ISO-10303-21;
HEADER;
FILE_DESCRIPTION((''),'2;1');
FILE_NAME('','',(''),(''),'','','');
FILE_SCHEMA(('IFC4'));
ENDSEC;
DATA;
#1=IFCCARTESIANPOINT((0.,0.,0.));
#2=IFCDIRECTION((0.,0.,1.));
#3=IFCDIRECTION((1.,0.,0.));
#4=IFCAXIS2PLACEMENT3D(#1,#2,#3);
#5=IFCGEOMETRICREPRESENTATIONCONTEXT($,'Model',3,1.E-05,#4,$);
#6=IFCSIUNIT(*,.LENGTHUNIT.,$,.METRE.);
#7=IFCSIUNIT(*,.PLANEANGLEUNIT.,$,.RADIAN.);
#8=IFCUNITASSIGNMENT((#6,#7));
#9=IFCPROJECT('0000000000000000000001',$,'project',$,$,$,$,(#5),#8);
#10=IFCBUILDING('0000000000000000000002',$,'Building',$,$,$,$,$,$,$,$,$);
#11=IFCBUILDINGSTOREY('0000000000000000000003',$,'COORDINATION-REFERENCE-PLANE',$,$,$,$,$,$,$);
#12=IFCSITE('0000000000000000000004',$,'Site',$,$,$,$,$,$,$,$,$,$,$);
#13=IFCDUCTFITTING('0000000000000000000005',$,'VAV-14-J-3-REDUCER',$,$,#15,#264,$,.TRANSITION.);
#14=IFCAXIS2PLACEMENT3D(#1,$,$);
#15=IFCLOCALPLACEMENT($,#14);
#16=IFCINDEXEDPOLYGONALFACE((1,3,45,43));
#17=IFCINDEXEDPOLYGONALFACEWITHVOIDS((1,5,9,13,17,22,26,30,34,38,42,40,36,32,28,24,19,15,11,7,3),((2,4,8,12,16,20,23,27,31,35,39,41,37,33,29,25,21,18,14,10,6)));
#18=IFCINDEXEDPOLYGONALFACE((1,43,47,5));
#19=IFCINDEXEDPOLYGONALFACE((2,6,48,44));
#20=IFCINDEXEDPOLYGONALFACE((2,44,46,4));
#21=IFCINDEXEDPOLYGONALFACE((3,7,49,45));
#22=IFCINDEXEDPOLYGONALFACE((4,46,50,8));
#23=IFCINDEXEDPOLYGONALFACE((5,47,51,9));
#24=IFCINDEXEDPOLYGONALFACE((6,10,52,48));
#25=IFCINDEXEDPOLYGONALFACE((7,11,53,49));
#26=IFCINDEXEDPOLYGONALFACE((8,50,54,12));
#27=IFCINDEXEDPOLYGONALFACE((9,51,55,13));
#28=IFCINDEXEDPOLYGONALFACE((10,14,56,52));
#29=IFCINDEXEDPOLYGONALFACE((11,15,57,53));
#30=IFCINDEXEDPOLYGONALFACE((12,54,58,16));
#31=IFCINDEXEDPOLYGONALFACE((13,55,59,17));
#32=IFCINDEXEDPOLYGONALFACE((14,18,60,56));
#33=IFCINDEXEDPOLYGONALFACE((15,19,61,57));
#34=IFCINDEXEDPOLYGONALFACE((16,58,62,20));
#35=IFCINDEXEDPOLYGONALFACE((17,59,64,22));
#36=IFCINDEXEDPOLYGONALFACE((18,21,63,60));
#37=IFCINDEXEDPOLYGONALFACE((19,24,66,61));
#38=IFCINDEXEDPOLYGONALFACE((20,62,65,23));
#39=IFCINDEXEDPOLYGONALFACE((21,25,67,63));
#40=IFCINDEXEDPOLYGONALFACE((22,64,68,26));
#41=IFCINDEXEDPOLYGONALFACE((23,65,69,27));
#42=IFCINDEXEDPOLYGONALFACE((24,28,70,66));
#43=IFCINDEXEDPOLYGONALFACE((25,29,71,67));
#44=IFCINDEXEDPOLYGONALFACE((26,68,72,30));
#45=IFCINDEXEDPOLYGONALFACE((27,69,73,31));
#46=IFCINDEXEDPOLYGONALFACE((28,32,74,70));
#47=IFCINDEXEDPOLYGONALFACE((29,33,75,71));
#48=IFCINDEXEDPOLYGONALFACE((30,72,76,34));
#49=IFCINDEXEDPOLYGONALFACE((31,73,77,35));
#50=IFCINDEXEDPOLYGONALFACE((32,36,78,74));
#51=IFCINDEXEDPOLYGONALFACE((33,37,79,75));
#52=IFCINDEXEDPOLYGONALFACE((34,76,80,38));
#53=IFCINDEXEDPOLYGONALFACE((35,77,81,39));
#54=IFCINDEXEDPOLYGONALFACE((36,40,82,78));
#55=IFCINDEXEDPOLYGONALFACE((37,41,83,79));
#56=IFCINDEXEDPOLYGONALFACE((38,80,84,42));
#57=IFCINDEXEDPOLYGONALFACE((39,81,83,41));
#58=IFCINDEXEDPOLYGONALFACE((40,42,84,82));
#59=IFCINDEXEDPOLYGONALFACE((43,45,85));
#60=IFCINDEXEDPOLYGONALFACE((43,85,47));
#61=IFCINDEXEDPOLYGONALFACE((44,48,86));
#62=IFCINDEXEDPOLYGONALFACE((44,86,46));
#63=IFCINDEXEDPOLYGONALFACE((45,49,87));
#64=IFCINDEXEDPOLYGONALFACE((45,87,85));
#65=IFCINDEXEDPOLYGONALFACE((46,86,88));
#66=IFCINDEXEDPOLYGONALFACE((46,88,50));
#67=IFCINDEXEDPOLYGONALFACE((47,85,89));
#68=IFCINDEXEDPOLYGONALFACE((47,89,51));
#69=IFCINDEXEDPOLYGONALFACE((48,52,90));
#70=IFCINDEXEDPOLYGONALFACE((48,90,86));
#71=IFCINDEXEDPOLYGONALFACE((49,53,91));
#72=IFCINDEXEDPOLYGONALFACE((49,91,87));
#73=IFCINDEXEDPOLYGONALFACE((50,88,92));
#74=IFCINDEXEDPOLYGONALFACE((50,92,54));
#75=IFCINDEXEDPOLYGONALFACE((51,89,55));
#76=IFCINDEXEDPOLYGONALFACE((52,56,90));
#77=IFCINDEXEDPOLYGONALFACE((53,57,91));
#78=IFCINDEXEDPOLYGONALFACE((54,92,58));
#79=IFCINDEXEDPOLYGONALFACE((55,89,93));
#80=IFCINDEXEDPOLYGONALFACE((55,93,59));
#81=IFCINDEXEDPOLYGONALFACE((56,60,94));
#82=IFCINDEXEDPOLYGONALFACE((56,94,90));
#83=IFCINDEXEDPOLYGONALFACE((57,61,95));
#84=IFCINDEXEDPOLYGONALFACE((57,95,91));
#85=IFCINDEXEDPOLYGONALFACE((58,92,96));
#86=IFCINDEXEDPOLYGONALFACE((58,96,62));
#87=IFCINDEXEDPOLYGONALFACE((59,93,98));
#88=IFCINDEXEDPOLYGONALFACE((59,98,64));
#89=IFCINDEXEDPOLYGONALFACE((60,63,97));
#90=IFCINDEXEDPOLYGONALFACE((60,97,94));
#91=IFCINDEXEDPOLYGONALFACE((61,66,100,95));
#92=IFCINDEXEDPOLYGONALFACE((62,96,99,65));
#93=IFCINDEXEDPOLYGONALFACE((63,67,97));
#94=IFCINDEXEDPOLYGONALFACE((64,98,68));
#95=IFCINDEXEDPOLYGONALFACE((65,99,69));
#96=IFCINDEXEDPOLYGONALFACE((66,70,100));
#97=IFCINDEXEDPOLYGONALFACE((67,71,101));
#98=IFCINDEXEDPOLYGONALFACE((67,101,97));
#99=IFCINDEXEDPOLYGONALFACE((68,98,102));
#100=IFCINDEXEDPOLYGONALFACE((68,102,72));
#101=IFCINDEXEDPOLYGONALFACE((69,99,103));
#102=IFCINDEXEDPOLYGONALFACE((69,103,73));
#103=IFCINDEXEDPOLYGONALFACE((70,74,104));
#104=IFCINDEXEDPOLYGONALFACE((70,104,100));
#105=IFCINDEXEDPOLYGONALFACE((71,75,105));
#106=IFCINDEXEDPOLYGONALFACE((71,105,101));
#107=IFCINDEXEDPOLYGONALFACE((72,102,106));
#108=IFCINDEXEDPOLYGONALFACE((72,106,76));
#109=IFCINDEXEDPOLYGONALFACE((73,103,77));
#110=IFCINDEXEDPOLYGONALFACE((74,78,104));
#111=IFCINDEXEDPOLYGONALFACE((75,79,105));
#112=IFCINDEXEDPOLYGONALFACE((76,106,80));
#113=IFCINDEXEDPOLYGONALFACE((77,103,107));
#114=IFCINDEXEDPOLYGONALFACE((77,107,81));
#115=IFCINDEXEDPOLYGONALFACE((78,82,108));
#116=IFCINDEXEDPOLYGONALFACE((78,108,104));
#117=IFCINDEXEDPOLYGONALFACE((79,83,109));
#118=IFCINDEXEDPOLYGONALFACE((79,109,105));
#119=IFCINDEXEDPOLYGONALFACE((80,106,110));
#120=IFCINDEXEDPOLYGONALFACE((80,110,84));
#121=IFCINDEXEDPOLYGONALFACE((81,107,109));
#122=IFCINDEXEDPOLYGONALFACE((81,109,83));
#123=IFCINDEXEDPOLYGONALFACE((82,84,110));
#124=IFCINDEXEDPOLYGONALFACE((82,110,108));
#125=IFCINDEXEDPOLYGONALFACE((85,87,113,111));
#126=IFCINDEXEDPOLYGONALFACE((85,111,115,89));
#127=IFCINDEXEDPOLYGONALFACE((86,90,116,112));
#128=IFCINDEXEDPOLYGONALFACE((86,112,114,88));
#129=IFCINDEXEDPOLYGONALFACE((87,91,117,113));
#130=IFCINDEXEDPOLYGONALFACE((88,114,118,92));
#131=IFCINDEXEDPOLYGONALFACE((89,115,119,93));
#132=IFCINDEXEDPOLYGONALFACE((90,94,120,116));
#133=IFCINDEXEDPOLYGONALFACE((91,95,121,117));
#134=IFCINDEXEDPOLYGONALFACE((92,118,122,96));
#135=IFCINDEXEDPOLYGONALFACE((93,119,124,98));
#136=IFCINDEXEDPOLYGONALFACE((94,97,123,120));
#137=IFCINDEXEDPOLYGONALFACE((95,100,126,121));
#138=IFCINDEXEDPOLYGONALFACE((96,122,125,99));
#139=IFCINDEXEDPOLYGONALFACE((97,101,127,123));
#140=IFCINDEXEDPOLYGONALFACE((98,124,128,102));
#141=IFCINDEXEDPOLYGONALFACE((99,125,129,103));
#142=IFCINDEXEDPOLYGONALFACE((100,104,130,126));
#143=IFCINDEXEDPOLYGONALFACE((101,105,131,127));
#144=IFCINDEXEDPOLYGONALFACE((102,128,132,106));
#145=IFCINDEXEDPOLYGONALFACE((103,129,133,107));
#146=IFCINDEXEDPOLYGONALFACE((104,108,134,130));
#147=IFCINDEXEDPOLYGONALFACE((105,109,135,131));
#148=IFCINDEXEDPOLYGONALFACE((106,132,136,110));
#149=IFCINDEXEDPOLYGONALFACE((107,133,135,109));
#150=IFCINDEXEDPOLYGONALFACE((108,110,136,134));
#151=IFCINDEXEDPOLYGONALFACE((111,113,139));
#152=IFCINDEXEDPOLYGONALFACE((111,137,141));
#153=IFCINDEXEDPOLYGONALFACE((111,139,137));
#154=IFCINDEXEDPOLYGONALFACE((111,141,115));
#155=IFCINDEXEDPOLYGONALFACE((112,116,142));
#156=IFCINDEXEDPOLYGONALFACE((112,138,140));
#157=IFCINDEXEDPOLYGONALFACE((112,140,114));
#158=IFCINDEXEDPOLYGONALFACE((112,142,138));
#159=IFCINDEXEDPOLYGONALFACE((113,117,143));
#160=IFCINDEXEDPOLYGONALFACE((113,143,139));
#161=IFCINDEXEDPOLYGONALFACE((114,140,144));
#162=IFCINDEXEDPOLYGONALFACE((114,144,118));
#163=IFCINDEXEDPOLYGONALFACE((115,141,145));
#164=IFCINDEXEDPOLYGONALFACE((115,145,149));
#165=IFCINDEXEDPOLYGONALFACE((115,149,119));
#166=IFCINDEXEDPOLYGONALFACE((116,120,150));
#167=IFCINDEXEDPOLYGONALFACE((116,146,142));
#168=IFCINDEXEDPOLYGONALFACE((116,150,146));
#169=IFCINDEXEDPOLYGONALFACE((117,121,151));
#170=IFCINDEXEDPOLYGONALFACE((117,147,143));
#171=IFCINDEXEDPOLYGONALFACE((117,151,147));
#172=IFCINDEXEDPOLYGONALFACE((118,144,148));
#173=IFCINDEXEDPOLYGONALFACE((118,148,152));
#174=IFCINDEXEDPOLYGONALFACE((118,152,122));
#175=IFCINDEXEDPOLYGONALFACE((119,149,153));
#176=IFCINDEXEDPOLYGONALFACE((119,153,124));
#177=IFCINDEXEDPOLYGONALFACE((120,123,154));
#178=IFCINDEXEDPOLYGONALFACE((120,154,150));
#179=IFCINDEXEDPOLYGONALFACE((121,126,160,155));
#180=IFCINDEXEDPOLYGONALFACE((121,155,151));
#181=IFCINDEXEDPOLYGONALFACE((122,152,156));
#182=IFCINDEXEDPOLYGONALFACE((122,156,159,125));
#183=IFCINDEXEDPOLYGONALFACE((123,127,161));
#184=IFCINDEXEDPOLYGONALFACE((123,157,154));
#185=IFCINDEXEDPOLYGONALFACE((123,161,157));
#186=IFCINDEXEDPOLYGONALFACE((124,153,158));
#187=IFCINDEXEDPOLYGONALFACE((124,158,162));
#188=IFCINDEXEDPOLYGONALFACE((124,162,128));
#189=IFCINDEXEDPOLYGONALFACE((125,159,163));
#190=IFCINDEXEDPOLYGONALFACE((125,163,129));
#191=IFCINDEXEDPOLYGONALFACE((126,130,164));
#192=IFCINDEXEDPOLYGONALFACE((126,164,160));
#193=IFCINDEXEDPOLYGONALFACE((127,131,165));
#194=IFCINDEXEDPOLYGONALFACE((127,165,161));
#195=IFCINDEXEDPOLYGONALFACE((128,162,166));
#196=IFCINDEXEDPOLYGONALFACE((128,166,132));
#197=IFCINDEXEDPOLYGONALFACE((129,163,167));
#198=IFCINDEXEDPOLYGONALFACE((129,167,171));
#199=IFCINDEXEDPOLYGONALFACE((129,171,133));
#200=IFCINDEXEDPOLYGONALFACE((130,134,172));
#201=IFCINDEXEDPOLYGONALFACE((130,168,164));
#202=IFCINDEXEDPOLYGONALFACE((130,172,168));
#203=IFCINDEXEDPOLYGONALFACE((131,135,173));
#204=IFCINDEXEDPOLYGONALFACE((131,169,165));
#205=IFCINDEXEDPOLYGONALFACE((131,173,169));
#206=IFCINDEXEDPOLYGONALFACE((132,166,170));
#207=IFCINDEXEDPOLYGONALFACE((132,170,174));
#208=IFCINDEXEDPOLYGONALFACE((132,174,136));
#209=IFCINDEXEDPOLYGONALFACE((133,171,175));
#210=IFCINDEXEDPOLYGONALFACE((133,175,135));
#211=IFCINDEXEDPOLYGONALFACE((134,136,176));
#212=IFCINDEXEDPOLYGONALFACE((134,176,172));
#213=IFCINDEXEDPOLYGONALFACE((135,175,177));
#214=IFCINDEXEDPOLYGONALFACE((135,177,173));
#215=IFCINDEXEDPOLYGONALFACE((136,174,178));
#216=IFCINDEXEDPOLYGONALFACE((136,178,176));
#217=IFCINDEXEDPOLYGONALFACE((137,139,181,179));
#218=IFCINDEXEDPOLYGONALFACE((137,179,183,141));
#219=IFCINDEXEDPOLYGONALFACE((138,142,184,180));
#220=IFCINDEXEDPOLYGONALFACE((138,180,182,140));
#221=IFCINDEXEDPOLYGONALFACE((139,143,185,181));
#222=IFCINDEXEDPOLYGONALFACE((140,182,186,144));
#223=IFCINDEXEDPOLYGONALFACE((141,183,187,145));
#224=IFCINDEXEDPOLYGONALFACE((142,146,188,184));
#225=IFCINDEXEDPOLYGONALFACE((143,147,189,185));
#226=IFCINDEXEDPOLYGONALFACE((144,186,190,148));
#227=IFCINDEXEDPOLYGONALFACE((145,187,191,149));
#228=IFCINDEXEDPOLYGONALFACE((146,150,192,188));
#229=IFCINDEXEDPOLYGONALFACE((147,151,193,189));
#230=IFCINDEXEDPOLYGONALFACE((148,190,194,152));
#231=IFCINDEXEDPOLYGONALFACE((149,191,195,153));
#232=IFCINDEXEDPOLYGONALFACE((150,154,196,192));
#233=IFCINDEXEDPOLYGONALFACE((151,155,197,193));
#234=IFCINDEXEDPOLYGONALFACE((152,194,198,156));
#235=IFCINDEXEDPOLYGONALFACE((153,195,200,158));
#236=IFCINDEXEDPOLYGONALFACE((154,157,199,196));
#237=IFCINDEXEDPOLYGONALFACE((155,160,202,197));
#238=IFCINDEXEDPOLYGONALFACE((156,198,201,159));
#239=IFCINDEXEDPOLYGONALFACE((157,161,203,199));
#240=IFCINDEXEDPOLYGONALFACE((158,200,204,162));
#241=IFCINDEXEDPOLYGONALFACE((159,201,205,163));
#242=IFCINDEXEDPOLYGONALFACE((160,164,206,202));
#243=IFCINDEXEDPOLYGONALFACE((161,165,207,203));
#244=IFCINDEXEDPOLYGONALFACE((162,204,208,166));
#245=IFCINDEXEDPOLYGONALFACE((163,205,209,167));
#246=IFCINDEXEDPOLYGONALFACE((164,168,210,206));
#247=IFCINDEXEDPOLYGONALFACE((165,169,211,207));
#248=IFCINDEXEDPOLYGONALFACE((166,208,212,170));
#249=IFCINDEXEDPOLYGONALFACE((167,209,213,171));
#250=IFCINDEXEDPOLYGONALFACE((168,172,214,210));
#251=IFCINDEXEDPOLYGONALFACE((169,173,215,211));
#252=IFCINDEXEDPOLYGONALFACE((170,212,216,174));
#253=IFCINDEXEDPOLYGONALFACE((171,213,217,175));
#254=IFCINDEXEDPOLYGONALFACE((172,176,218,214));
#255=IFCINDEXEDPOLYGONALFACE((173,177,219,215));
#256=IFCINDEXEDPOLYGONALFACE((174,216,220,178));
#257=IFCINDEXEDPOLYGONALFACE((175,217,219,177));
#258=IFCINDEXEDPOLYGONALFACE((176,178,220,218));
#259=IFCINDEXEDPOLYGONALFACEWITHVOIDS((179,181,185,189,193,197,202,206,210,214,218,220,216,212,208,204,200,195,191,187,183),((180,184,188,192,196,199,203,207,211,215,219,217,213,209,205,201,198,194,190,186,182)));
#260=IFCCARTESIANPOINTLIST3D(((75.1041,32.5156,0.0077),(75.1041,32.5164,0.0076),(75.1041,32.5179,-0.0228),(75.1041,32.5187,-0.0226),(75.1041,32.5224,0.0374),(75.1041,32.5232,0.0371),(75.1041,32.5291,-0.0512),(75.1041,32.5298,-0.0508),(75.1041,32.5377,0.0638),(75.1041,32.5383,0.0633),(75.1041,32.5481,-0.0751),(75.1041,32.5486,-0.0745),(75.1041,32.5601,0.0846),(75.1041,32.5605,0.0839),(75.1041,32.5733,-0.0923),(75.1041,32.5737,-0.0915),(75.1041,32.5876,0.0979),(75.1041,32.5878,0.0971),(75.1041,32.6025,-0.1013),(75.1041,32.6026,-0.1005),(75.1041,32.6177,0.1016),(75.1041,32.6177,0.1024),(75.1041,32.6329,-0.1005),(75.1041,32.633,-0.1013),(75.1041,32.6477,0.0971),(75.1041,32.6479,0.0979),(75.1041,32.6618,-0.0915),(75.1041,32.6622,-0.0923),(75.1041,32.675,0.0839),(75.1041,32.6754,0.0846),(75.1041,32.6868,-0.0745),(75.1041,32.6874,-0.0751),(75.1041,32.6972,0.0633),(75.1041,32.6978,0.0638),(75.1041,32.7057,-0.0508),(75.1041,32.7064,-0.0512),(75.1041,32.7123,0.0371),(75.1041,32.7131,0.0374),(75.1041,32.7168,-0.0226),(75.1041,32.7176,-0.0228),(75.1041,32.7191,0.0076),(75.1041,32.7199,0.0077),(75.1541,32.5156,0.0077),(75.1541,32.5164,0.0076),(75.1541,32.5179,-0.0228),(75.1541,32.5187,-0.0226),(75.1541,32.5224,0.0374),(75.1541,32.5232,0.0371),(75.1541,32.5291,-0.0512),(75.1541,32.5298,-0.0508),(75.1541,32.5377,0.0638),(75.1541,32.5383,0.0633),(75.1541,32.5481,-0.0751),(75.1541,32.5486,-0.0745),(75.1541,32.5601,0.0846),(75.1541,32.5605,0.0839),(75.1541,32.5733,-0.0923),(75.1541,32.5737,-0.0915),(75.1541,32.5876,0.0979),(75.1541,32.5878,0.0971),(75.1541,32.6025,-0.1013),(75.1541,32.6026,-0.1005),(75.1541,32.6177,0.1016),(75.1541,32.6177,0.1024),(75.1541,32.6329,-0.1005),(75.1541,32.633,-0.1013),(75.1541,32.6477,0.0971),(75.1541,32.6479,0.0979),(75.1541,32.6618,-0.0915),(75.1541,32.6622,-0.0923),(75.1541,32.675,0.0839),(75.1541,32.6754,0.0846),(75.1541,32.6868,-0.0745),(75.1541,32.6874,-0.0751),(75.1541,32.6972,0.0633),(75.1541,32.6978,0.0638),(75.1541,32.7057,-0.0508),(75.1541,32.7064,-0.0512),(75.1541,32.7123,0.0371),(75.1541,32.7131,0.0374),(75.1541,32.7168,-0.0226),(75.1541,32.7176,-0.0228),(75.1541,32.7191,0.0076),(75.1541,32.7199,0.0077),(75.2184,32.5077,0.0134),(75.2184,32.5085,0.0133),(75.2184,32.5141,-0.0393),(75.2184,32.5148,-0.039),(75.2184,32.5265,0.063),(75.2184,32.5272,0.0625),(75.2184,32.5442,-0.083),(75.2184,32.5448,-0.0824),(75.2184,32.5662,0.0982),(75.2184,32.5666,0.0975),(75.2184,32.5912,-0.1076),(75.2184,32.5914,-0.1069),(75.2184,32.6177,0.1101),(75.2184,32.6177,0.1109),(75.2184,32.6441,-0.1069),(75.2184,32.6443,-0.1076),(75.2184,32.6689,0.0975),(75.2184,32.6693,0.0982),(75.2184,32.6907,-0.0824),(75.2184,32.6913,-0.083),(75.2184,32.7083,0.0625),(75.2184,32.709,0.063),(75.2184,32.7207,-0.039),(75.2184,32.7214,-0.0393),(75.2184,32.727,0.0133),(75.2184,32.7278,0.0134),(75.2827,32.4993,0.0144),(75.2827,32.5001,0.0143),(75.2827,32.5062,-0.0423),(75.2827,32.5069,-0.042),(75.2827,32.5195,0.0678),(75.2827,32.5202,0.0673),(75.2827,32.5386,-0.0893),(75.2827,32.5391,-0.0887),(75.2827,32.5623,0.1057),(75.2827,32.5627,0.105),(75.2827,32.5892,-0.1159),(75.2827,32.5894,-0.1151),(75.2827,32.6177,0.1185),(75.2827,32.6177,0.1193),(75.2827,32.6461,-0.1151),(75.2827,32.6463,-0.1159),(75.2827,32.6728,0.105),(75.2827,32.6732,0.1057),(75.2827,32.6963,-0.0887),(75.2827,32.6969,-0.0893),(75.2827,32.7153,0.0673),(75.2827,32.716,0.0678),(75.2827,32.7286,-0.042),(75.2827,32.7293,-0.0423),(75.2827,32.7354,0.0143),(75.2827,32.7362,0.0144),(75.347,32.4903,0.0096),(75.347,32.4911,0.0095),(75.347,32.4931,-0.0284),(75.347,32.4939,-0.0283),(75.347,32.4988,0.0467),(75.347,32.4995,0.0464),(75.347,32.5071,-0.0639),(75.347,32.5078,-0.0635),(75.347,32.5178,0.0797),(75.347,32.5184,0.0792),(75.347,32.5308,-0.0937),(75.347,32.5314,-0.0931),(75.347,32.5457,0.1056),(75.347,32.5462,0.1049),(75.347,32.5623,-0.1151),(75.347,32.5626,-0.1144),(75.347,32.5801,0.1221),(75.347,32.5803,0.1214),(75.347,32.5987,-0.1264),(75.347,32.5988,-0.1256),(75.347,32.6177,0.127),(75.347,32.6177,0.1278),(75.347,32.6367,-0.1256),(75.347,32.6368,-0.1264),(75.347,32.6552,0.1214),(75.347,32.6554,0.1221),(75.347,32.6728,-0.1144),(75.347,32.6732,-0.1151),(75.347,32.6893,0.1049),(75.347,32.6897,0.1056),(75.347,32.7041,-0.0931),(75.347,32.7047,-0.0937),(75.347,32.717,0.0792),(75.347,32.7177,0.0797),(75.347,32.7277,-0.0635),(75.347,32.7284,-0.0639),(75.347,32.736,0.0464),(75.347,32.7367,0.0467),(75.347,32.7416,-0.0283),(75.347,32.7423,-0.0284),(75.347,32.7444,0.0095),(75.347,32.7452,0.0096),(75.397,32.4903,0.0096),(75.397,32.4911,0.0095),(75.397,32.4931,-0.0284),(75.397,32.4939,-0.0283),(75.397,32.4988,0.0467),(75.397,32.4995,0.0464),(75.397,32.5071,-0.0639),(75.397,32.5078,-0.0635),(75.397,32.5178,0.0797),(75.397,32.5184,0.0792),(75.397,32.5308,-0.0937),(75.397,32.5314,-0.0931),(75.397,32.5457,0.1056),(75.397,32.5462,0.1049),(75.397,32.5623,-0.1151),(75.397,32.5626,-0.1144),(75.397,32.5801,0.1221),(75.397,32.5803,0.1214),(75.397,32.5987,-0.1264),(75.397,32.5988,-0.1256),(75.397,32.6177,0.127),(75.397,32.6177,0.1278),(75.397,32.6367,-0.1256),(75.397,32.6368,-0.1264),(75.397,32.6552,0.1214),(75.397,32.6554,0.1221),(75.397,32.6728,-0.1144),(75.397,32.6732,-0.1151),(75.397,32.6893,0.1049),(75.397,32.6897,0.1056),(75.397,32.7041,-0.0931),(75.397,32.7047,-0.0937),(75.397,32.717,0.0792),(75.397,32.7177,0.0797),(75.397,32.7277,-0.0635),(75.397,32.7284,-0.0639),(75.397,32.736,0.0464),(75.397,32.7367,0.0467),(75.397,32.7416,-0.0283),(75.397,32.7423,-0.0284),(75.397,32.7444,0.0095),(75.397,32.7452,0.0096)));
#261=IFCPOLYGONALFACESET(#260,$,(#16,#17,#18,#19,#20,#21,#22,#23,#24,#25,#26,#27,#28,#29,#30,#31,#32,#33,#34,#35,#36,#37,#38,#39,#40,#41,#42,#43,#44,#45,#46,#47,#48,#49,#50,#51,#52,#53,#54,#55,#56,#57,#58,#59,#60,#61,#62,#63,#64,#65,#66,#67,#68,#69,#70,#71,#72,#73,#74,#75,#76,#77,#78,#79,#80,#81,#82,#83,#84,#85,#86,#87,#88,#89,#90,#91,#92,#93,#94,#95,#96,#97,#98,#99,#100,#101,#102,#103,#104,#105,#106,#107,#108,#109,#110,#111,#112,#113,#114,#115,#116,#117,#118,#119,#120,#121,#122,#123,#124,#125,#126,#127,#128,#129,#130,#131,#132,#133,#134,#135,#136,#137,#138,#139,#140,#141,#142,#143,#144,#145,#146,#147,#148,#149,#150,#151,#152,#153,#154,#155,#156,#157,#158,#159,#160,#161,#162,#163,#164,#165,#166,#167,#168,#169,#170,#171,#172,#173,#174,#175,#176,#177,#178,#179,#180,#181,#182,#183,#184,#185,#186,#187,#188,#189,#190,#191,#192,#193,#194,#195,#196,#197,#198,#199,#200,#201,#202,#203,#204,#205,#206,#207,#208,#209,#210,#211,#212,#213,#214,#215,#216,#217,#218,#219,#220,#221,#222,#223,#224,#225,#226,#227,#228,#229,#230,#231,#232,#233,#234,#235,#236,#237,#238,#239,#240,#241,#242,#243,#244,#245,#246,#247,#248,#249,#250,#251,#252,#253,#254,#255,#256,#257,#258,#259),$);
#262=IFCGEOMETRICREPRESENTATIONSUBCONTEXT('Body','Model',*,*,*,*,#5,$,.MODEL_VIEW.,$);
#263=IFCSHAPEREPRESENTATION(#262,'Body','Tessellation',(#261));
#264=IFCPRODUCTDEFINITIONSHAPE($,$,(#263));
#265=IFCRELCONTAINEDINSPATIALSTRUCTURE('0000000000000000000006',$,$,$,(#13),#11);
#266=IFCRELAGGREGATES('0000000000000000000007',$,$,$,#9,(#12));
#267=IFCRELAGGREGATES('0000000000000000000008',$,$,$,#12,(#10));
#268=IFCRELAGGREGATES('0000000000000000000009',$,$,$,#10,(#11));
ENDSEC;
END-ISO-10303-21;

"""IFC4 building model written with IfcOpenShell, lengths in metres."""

from ifc_helpers import new_model, entity, si_unit, frame, origin_with_axes, place, context, subcontext, project, spatial, element, save


model = new_model("IFC4")

# Units and contexts
model_context = context("Model", 3, precision=1e-05, world=origin_with_axes())
body_context_1 = subcontext(model_context, "Body", "Model", "MODEL_VIEW")
ifc_project = project(units=[si_unit("LENGTHUNIT", "METRE"), si_unit("PLANEANGLEUNIT", "RADIAN")], contexts=[model_context])

# Site, building, storey
site = spatial("IfcSite", under=ifc_project, Name="Site")
building = spatial("IfcBuilding", under=site, Name="Building")
storey = spatial("IfcBuildingStorey", under=building, Name="COORDINATION-REFERENCE-PLANE")

# Duct fitting
for number, where, z_axis, x_axis, name in (
    (1, (75.397, 32.6177, 0.0), (0.0, -1.0, 0.0), (0.0, 0.0, 1.0), "VAV-14-J-3-REDUCER"),
):
    element("IfcDuctFitting", number, at=place(None, frame(where, z_axis=z_axis, x_axis=x_axis)), inside=storey, Name=name, PredefinedType="TRANSITION", context=body_context_1, shape_type="SweptSolid", body=[
        entity("IfcRevolvedAreaSolid", entity("IfcArbitraryClosedProfileDef", "AREA", None, entity("IfcPolyline", [entity("IfcCartesianPoint", [0.1278, 0.0]), entity("IfcCartesianPoint", [0.1278, 0.05]), entity("IfcCartesianPoint", [0.1024, 0.2429]), entity("IfcCartesianPoint", [0.1024, 0.2929]), entity("IfcCartesianPoint", [0.1016, 0.2929]), entity("IfcCartesianPoint", [0.1016, 0.2429]), entity("IfcCartesianPoint", [0.127, 0.05]), entity("IfcCartesianPoint", [0.127, 0.0]), entity("IfcCartesianPoint", [0.1278, 0.0])])), entity("IfcAxis2Placement3D", entity("IfcCartesianPoint", [0.0, 0.0, 0.0])), entity("IfcAxis1Placement", entity("IfcCartesianPoint", [0.0, 0.0, 0.0]), entity("IfcDirection", [0.0, 1.0, 0.0])), 6.283185),
    ])

save(model, "model.ifc")
